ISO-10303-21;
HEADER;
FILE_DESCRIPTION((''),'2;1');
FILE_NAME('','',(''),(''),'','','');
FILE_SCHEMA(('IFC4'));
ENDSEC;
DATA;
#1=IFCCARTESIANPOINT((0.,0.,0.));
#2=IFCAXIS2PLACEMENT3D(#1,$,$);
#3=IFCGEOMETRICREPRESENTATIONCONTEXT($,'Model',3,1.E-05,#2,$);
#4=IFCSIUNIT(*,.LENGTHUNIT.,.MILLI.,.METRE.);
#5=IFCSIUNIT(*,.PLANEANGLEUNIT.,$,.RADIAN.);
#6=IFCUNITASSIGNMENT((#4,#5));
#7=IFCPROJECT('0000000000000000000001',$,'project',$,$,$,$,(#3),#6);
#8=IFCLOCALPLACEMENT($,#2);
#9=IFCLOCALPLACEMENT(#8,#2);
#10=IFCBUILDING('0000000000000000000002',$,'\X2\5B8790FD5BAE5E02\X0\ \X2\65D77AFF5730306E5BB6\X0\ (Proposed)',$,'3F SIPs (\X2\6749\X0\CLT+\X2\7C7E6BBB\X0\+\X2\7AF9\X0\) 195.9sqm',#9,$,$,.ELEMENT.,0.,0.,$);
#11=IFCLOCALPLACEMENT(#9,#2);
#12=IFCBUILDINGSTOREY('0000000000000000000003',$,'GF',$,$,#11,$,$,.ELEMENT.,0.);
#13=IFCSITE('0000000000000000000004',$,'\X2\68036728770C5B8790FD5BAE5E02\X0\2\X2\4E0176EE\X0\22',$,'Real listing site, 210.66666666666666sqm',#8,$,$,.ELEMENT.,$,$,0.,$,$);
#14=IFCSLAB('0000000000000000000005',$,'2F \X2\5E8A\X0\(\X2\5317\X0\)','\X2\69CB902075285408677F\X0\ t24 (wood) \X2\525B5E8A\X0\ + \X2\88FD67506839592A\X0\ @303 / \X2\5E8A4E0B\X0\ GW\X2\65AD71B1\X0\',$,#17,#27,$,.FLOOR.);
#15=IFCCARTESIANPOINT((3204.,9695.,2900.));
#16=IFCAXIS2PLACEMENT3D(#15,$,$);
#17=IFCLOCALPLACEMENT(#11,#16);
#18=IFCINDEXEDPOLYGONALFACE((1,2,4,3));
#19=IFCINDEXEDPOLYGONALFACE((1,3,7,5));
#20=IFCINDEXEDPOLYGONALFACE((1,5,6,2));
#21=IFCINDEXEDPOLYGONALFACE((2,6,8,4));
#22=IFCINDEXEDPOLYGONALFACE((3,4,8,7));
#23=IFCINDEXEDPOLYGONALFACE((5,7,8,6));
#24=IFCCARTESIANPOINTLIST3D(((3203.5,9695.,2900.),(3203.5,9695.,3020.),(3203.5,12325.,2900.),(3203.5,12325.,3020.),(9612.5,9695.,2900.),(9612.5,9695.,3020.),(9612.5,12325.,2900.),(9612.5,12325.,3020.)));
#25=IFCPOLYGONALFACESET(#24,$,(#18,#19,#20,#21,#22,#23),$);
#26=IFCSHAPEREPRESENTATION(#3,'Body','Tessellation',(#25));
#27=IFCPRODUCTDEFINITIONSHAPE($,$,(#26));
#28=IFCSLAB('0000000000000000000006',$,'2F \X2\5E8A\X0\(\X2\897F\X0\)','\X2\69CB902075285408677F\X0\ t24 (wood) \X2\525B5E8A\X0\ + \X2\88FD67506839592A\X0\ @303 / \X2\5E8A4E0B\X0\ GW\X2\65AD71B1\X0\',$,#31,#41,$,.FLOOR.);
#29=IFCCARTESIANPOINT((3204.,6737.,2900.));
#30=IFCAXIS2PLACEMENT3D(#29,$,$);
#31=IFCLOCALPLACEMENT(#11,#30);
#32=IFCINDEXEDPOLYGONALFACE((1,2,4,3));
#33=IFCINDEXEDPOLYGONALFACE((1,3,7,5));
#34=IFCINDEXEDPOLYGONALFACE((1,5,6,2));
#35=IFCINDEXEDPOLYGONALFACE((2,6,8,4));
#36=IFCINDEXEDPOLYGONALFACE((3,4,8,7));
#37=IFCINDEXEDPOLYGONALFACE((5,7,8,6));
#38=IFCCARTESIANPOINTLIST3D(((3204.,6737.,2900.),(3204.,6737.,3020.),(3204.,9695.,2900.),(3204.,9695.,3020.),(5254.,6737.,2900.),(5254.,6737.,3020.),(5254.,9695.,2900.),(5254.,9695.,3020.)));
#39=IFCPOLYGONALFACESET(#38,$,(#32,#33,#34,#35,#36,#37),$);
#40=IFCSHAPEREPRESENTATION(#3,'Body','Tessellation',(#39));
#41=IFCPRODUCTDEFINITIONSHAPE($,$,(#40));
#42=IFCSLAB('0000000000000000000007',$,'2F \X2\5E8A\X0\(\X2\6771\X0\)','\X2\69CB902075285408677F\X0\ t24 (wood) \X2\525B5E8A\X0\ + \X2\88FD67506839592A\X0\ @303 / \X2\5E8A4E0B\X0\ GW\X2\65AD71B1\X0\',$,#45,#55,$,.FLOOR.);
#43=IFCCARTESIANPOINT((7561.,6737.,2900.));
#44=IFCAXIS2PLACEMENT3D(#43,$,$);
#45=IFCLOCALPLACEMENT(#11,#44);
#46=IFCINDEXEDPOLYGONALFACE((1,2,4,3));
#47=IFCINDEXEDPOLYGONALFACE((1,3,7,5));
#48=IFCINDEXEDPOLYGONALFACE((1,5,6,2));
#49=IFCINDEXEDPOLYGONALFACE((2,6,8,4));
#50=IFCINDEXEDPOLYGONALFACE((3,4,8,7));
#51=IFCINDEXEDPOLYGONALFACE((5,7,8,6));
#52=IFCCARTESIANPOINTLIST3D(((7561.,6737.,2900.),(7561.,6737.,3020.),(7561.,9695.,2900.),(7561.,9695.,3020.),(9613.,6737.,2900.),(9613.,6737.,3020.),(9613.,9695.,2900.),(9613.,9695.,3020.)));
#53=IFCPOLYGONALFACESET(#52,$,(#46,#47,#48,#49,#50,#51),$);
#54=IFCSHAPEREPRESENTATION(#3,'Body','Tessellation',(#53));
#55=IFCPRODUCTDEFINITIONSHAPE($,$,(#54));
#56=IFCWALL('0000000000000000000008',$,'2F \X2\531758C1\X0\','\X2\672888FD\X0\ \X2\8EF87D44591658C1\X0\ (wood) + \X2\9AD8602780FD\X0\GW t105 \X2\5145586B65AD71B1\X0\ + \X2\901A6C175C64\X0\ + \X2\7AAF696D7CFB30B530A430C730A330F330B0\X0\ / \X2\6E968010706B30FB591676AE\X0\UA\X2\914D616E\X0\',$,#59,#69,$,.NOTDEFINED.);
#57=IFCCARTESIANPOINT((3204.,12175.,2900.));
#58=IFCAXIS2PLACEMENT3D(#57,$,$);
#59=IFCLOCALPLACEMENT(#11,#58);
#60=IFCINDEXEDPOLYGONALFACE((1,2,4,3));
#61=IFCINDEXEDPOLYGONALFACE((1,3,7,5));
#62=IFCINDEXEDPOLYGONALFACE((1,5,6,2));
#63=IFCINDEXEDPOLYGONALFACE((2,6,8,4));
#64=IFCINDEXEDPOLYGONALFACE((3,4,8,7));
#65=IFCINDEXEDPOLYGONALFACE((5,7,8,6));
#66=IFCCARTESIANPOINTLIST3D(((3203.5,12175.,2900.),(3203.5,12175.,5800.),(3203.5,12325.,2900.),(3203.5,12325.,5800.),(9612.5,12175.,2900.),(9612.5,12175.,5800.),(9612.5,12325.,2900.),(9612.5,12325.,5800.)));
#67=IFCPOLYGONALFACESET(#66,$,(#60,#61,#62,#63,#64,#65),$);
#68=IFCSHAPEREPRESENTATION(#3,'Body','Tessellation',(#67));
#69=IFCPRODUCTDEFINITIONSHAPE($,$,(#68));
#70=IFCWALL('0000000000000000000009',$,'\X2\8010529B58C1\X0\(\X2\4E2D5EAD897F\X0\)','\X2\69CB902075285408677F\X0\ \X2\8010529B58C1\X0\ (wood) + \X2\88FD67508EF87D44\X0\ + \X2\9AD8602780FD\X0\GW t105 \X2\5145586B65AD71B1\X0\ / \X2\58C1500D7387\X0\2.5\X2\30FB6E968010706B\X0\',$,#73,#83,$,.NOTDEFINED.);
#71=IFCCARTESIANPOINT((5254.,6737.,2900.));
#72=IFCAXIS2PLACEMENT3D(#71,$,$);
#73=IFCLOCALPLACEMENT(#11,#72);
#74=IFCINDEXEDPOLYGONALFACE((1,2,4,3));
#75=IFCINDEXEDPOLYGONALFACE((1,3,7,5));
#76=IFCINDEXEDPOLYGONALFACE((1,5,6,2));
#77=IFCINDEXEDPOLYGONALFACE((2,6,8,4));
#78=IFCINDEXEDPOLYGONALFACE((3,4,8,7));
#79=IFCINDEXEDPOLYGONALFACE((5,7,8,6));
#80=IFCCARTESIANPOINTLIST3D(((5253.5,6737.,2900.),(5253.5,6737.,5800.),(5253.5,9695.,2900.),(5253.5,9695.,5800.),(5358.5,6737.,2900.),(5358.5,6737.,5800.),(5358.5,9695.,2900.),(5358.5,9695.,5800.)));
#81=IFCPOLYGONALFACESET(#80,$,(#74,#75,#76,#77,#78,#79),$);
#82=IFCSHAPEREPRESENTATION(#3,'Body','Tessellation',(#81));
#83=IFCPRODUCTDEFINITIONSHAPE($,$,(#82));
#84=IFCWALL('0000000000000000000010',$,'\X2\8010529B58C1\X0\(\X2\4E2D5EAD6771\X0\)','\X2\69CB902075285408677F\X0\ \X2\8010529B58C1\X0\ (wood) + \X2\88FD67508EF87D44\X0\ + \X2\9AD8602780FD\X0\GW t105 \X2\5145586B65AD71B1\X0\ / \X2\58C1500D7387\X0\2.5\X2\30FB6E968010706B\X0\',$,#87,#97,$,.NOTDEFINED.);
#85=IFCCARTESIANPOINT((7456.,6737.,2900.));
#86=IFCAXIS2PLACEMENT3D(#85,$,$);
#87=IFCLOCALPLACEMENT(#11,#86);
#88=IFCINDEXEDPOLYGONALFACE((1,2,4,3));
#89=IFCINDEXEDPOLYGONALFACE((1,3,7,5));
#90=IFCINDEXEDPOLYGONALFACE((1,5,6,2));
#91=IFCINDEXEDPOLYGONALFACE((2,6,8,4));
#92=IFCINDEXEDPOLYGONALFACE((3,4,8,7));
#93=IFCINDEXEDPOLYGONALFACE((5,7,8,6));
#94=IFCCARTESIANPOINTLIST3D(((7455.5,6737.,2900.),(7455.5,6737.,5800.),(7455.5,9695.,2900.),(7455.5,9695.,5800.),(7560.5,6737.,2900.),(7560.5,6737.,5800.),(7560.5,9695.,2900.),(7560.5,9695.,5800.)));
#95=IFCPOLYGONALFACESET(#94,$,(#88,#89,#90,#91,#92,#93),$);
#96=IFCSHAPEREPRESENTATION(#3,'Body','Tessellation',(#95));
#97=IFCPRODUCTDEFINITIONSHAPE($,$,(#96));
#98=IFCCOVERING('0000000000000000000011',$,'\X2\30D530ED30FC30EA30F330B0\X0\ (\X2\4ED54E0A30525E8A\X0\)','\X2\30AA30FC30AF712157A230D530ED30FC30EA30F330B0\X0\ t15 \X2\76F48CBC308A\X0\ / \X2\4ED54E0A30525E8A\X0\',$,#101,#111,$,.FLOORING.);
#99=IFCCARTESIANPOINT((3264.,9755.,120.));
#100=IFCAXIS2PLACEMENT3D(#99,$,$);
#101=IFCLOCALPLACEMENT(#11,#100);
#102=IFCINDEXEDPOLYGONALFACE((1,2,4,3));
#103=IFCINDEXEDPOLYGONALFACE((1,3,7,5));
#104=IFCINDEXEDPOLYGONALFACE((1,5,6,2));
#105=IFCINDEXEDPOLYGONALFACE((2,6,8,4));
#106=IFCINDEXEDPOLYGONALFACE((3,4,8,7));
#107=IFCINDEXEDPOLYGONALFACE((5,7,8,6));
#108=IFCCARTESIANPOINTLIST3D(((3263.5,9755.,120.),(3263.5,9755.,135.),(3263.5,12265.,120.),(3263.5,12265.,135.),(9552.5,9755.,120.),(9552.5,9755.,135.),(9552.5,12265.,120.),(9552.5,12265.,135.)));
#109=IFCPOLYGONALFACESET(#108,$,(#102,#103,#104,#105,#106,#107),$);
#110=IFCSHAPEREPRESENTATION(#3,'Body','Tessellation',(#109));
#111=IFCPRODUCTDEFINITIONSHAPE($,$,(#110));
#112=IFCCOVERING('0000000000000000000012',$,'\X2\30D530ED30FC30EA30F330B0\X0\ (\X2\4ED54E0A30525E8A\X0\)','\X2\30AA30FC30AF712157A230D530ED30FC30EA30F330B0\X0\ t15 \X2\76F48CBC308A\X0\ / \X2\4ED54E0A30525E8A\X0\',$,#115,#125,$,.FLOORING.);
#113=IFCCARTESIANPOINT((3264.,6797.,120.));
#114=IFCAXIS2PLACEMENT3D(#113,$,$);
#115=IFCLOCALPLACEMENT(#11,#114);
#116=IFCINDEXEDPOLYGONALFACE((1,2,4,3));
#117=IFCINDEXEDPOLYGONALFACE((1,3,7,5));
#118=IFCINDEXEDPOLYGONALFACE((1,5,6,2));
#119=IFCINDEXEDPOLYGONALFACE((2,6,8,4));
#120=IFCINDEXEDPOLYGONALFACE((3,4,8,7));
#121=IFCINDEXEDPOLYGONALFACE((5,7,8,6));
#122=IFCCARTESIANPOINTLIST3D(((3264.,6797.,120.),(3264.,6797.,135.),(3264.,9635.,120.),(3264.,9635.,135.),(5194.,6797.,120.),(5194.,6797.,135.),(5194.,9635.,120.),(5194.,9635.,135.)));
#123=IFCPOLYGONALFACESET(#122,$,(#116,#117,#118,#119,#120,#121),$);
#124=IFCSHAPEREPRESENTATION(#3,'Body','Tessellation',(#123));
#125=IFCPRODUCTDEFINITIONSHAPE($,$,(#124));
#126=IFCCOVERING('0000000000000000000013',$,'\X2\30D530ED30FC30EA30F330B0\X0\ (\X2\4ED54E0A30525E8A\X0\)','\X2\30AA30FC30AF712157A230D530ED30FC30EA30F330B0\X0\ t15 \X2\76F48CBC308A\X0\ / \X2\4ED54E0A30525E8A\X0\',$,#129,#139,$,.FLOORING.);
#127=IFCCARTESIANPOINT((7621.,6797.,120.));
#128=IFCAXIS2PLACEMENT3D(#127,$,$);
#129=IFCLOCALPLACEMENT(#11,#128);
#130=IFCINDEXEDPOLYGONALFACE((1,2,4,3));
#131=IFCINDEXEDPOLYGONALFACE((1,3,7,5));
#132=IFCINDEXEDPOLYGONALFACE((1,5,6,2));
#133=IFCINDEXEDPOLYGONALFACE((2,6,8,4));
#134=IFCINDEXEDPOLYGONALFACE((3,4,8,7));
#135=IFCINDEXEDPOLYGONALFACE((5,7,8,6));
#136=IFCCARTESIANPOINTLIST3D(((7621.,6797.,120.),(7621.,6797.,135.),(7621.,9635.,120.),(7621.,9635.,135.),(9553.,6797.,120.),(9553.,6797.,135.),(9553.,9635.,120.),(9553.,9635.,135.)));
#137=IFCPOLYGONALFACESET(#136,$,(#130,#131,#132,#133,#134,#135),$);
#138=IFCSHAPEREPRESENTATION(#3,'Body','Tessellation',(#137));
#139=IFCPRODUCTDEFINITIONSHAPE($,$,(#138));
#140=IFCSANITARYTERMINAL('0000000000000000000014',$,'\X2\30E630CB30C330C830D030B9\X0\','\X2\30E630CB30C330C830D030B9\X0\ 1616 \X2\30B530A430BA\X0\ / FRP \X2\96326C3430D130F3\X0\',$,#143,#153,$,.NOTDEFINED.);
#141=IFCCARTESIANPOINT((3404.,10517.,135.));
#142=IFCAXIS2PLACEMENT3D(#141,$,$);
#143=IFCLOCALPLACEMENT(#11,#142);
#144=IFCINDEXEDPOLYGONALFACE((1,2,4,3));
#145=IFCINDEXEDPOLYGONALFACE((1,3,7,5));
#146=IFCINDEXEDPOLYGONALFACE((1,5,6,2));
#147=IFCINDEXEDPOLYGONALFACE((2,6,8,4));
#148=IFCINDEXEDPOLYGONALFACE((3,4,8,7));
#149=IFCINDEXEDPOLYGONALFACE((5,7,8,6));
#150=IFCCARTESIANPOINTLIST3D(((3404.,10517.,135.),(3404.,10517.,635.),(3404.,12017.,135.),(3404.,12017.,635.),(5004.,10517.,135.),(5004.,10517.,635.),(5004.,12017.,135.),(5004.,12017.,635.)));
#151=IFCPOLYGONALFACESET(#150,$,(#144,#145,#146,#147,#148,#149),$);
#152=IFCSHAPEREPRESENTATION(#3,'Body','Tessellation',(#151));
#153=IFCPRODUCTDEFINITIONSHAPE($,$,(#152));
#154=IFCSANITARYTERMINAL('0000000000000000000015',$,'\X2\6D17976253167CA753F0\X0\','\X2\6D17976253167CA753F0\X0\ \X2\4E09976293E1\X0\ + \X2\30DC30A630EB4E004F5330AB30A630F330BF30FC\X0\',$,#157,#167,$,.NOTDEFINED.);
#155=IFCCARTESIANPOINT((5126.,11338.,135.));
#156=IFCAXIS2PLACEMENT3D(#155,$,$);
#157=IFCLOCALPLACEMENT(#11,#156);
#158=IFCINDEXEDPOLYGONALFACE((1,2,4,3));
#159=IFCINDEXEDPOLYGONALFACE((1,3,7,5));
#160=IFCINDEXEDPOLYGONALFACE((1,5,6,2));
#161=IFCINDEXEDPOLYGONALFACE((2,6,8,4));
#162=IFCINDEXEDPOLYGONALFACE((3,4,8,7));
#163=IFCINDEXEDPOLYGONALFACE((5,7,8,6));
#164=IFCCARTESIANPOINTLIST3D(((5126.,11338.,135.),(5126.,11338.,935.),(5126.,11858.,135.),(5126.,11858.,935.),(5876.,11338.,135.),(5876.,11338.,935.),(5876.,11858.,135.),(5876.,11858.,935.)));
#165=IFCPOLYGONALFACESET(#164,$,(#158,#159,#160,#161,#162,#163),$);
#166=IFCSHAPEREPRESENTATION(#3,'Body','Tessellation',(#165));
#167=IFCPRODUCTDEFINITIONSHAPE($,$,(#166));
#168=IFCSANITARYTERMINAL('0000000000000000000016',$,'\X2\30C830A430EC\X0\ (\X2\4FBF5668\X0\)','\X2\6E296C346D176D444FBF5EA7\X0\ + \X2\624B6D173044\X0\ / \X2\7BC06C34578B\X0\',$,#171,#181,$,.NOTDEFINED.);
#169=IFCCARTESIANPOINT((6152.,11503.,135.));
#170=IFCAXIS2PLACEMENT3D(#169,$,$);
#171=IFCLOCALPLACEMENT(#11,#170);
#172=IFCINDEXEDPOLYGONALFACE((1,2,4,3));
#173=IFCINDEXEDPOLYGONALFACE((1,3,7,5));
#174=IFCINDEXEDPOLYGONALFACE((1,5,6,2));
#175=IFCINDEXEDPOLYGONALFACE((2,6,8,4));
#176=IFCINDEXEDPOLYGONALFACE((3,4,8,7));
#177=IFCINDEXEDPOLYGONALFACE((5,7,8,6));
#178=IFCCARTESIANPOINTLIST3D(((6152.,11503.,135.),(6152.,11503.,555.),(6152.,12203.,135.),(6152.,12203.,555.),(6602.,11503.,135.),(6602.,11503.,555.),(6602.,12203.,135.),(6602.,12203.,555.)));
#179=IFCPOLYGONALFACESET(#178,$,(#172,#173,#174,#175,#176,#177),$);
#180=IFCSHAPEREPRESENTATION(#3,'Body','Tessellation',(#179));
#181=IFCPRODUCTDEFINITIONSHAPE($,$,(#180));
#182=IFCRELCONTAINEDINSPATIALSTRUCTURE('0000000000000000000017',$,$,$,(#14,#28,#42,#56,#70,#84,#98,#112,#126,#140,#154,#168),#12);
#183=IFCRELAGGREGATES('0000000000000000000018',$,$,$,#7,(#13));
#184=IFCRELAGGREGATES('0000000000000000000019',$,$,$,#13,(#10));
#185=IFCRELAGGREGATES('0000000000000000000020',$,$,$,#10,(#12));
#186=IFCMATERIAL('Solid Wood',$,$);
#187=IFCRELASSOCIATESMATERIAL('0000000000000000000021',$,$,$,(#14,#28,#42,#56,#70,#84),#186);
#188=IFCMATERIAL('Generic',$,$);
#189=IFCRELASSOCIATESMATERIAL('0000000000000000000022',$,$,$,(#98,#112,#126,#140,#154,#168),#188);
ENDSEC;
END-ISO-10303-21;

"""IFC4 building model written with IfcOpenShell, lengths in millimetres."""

from ifc_helpers import new_model, si_unit, frame, frame_2d, origin, place, context, project, spatial, rectangle, extrude, material, element, save


model = new_model("IFC4")

# Units and contexts
model_context = context("Model", 3, precision=1e-05, world=origin())
ifc_project = project(units=[si_unit("LENGTHUNIT", "METRE", prefix="MILLI"), si_unit("PLANEANGLEUNIT", "RADIAN")], contexts=[model_context])

# Site, building, storey
site_placement = place(None, origin())
site = spatial("IfcSite", under=ifc_project, at=site_placement, Name="栃木県宇都宮市2丁目22", ObjectType="Real listing site, 210.66666666666666sqm", CompositionType="ELEMENT", RefElevation=0.0)
building_placement = place(site_placement, origin())
building = spatial("IfcBuilding", under=site, at=building_placement, Name="宇都宮市 旗竿地の家 (Proposed)", ObjectType="3F SIPs (杉CLT+籾殻+竹) 195.9sqm", CompositionType="ELEMENT", ElevationOfRefHeight=0.0, ElevationOfTerrain=0.0)
storey_placement = place(building_placement, origin())
storey = spatial("IfcBuildingStorey", under=building, at=storey_placement, Name="GF", CompositionType="ELEMENT", Elevation=0.0)

# Slabs
ifc_material_1 = material(Name="Solid Wood")
slab_1_placement = place(storey_placement, frame((3204.0, 9695.0, 2900.0)))
element("IfcSlab", 1, at=slab_1_placement, inside=storey, material=ifc_material_1, Name="2F 床(北)", Description="構造用合板 t24 (wood) 剛床 + 製材根太 @303 / 床下 GW断熱", PredefinedType="FLOOR", context=model_context, shape_type="SweptSolid", body=[
    extrude(rectangle(XDim=6409.0, YDim=2630.0, at=frame_2d((3204.0, 1315.0))), frame((3204.0, 9695.0, 2900.0)), (0.0, 0.0, 1.0), 120.0),
])
slab_2_placement = place(storey_placement, frame((3204.0, 6737.0, 2900.0)))
element("IfcSlab", 2, at=slab_2_placement, inside=storey, material=ifc_material_1, Name="2F 床(西)", Description="構造用合板 t24 (wood) 剛床 + 製材根太 @303 / 床下 GW断熱", PredefinedType="FLOOR", context=model_context, shape_type="SweptSolid", body=[
    extrude(rectangle(XDim=2050.0, YDim=2958.0, at=frame_2d((1025.0, 1479.0))), frame((3204.0, 6737.0, 2900.0)), (0.0, 0.0, 1.0), 120.0),
])
slab_3_placement = place(storey_placement, frame((7561.0, 6737.0, 2900.0)))
element("IfcSlab", 3, at=slab_3_placement, inside=storey, material=ifc_material_1, Name="2F 床(東)", Description="構造用合板 t24 (wood) 剛床 + 製材根太 @303 / 床下 GW断熱", PredefinedType="FLOOR", context=model_context, shape_type="SweptSolid", body=[
    extrude(rectangle(XDim=2052.0, YDim=2958.0, at=frame_2d((1026.0, 1479.0))), frame((7561.0, 6737.0, 2900.0)), (0.0, 0.0, 1.0), 120.0),
])

# Wall
wall_1_placement = place(storey_placement, frame((3204.0, 12175.0, 2900.0)))
element("IfcWall", 4, at=wall_1_placement, inside=storey, material=ifc_material_1, Name="2F 北壁", Description="木製 軸組外壁 (wood) + 高性能GW t105 充填断熱 + 通気層 + 窯業系サイディング / 準耐火・外皮UA配慮", PredefinedType="NOTDEFINED", context=model_context, shape_type="SweptSolid", body=[
    extrude(rectangle(XDim=6409.0, YDim=150.0, at=frame_2d((3204.0, 75.0))), frame((3204.0, 12175.0, 2900.0)), (0.0, 0.0, 1.0), 2900.0),
])

# Walls
wall_2_placement = place(storey_placement, frame((5254.0, 6737.0, 2900.0)))
element("IfcWall", 5, at=wall_2_placement, inside=storey, material=ifc_material_1, Name="耐力壁(中庭西)", Description="構造用合板 耐力壁 (wood) + 製材軸組 + 高性能GW t105 充填断熱 / 壁倍率2.5・準耐火", PredefinedType="NOTDEFINED", context=model_context, shape_type="SweptSolid", body=[
    extrude(rectangle(XDim=105.0, YDim=2958.0, at=frame_2d((52.0, 1479.0))), frame((5254.0, 6737.0, 2900.0)), (0.0, 0.0, 1.0), 2900.0),
])
wall_3_placement = place(storey_placement, frame((7456.0, 6737.0, 2900.0)))
element("IfcWall", 6, at=wall_3_placement, inside=storey, material=ifc_material_1, Name="耐力壁(中庭東)", Description="構造用合板 耐力壁 (wood) + 製材軸組 + 高性能GW t105 充填断熱 / 壁倍率2.5・準耐火", PredefinedType="NOTDEFINED", context=model_context, shape_type="SweptSolid", body=[
    extrude(rectangle(XDim=105.0, YDim=2958.0, at=frame_2d((52.0, 1479.0))), frame((7456.0, 6737.0, 2900.0)), (0.0, 0.0, 1.0), 2900.0),
])

# Coverings
ifc_material_2 = material(Name="Generic")
covering_1_placement = place(storey_placement, frame((3264.0, 9755.0, 120.0)))
element("IfcCovering", 7, at=covering_1_placement, inside=storey, material=ifc_material_2, Name="フローリング (仕上げ床)", Description="オーク無垢フローリング t15 直貼り / 仕上げ床", PredefinedType="FLOORING", context=model_context, shape_type="SweptSolid", body=[
    extrude(rectangle(XDim=6289.0, YDim=2510.0, at=frame_2d((3144.0, 1255.0))), frame((3264.0, 9755.0, 120.0)), (0.0, 0.0, 1.0), 15.0),
])
covering_2_placement = place(storey_placement, frame((3264.0, 6797.0, 120.0)))
element("IfcCovering", 8, at=covering_2_placement, inside=storey, material=ifc_material_2, Name="フローリング (仕上げ床)", Description="オーク無垢フローリング t15 直貼り / 仕上げ床", PredefinedType="FLOORING", context=model_context, shape_type="SweptSolid", body=[
    extrude(rectangle(XDim=1930.0, YDim=2838.0, at=frame_2d((965.0, 1419.0))), frame((3264.0, 6797.0, 120.0)), (0.0, 0.0, 1.0), 15.0),
])
covering_3_placement = place(storey_placement, frame((7621.0, 6797.0, 120.0)))
element("IfcCovering", 9, at=covering_3_placement, inside=storey, material=ifc_material_2, Name="フローリング (仕上げ床)", Description="オーク無垢フローリング t15 直貼り / 仕上げ床", PredefinedType="FLOORING", context=model_context, shape_type="SweptSolid", body=[
    extrude(rectangle(XDim=1932.0, YDim=2838.0, at=frame_2d((966.0, 1419.0))), frame((7621.0, 6797.0, 120.0)), (0.0, 0.0, 1.0), 15.0),
])

# Sanitary terminals
sanitary_terminal_1_placement = place(storey_placement, frame((3404.0, 10517.0, 135.0)))
element("IfcSanitaryTerminal", 10, at=sanitary_terminal_1_placement, inside=storey, material=ifc_material_2, Name="ユニットバス", Description="ユニットバス 1616 サイズ / FRP 防水パン", PredefinedType="NOTDEFINED", context=model_context, shape_type="SweptSolid", body=[
    extrude(rectangle(XDim=1600.0, YDim=1500.0, at=frame_2d((800.0, 750.0))), frame((3404.0, 10517.0, 135.0)), (0.0, 0.0, 1.0), 500.0),
])
sanitary_terminal_2_placement = place(storey_placement, frame((5126.0, 11338.0, 135.0)))
element("IfcSanitaryTerminal", 11, at=sanitary_terminal_2_placement, inside=storey, material=ifc_material_2, Name="洗面化粧台", Description="洗面化粧台 三面鏡 + ボウル一体カウンター", PredefinedType="NOTDEFINED", context=model_context, shape_type="SweptSolid", body=[
    extrude(rectangle(XDim=750.0, YDim=520.0, at=frame_2d((375.0, 260.0))), frame((5126.0, 11338.0, 135.0)), (0.0, 0.0, 1.0), 800.0),
])
sanitary_terminal_3_placement = place(storey_placement, frame((6152.0, 11503.0, 135.0)))
element("IfcSanitaryTerminal", 12, at=sanitary_terminal_3_placement, inside=storey, material=ifc_material_2, Name="トイレ (便器)", Description="温水洗浄便座 + 手洗い / 節水型", PredefinedType="NOTDEFINED", context=model_context, shape_type="SweptSolid", body=[
    extrude(rectangle(XDim=450.0, YDim=700.0, at=frame_2d((225.0, 350.0))), frame((6152.0, 11503.0, 135.0)), (0.0, 0.0, 1.0), 420.0),
])

save(model, "model.ifc")
